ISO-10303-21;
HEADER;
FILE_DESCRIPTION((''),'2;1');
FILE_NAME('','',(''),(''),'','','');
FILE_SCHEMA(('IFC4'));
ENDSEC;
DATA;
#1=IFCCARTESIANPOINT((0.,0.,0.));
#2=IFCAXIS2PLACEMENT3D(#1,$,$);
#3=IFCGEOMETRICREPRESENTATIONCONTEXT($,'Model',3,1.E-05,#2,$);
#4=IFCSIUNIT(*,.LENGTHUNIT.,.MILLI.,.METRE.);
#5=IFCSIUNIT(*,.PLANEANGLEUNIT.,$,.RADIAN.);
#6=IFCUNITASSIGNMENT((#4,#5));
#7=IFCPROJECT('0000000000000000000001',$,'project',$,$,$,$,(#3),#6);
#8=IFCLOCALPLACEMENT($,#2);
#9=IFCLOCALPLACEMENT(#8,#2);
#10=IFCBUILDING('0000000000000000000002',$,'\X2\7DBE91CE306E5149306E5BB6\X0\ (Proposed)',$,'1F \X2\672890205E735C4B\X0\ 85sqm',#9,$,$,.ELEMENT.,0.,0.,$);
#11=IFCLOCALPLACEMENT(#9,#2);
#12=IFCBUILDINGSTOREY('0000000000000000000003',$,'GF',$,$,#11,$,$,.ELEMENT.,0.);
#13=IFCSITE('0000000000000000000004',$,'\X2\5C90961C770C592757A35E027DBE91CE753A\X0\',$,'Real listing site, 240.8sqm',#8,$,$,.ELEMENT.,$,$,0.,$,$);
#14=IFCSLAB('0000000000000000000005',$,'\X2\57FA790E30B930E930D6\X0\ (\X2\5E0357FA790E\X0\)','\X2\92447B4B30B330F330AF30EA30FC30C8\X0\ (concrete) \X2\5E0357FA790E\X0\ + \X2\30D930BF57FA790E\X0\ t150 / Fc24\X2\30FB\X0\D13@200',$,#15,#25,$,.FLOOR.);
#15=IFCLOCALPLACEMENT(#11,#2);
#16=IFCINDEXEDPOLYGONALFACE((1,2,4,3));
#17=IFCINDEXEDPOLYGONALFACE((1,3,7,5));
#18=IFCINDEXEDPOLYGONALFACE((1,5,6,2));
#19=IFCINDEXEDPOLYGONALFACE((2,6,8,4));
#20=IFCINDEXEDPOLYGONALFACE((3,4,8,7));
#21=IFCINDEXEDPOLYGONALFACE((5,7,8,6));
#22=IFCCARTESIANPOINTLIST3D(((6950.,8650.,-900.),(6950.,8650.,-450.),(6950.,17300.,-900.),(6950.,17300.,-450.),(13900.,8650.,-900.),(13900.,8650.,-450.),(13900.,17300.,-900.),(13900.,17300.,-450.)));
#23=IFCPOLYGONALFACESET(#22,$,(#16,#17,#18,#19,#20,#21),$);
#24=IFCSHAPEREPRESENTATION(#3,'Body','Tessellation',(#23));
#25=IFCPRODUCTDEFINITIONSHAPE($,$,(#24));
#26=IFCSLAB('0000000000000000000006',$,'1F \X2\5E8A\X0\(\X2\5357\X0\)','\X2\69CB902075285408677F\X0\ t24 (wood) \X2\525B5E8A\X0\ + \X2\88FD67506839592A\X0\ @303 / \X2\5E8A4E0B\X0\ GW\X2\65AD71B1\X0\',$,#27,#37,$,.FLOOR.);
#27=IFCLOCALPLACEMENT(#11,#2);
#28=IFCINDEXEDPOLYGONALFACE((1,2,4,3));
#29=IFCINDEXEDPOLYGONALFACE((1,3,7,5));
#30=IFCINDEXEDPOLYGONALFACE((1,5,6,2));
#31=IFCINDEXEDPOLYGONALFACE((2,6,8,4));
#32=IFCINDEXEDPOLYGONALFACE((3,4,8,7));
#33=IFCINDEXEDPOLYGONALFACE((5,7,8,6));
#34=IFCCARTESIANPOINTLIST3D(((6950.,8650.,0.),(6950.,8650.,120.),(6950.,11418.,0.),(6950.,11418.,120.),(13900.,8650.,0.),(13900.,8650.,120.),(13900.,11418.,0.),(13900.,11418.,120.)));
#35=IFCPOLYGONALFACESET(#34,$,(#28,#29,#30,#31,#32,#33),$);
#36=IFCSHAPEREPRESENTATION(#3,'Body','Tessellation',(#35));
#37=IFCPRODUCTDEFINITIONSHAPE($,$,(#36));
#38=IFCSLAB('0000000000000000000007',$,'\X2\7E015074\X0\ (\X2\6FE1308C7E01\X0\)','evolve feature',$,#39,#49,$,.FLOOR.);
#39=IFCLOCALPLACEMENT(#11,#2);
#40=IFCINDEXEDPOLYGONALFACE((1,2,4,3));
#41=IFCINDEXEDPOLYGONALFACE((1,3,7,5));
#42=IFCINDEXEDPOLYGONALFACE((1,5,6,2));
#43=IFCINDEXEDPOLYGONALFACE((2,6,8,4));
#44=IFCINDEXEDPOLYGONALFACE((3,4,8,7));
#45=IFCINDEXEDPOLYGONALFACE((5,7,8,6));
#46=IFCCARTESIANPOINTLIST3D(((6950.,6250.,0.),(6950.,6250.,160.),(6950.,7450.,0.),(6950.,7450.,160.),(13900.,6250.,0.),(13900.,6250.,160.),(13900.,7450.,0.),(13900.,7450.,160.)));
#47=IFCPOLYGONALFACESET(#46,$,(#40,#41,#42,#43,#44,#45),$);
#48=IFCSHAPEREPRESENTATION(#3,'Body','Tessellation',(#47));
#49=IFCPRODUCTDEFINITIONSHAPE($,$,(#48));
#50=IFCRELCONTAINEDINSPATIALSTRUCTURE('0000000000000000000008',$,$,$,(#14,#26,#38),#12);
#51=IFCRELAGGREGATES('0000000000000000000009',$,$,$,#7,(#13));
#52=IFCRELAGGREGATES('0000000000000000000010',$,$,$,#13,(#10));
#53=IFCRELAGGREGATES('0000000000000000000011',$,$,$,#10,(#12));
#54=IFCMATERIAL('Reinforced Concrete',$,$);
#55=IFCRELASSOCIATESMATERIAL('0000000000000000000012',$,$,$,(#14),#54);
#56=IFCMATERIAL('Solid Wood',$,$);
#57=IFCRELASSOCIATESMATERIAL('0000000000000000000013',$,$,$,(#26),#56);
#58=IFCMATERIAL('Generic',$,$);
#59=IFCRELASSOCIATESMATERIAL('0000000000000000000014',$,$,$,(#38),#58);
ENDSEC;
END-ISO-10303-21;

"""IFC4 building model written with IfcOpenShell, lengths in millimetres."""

from ifc_helpers import new_model, si_unit, frame, frame_2d, origin, place, context, project, spatial, rectangle, extrude, material, element, save


model = new_model("IFC4")

# Units and contexts
model_context = context("Model", 3, precision=1e-05, world=origin())
ifc_project = project(units=[si_unit("LENGTHUNIT", "METRE", prefix="MILLI"), si_unit("PLANEANGLEUNIT", "RADIAN")], contexts=[model_context])

# Site, building, storey
site_placement = place(None, origin())
site = spatial("IfcSite", under=ifc_project, at=site_placement, Name="岐阜県大垣市綾野町", ObjectType="Real listing site, 240.8sqm", CompositionType="ELEMENT", RefElevation=0.0)
building_placement = place(site_placement, origin())
building = spatial("IfcBuilding", under=site, at=building_placement, Name="綾野の光の家 (Proposed)", ObjectType="1F 木造平屋 85sqm", CompositionType="ELEMENT", ElevationOfRefHeight=0.0, ElevationOfTerrain=0.0)
storey_placement = place(building_placement, origin())
storey = spatial("IfcBuildingStorey", under=building, at=storey_placement, Name="GF", CompositionType="ELEMENT", Elevation=0.0)

# Slabs
ifc_material_1 = material(Name="Reinforced Concrete")
slab_1_placement = place(storey_placement, frame((3475.0, 4325.0, -450.0)))
element("IfcSlab", 1, at=slab_1_placement, inside=storey, material=ifc_material_1, Name="基礎スラブ (布基礎)", Description="鉄筋コンクリート (concrete) 布基礎 + ベタ基礎 t150 / Fc24・D13@200", PredefinedType="FLOOR", context=model_context, shape_type="SweptSolid", body=[
    extrude(rectangle(XDim=6950.0, YDim=8650.0, at=frame_2d((3475.0, 4325.0))), frame((3475.0, 4325.0, -450.0)), (0.0, 0.0, 1.0), 450.0),
])
ifc_material_2 = material(Name="Solid Wood")
slab_2_placement = place(storey_placement, frame((3475.0, 4325.0, 0.0)))
element("IfcSlab", 2, at=slab_2_placement, inside=storey, material=ifc_material_2, Name="1F 床(南)", Description="構造用合板 t24 (wood) 剛床 + 製材根太 @303 / 床下 GW断熱", PredefinedType="FLOOR", context=model_context, shape_type="SweptSolid", body=[
    extrude(rectangle(XDim=6950.0, YDim=2768.0, at=frame_2d((3475.0, 1384.0))), frame((3475.0, 4325.0, 0.0)), (0.0, 0.0, 1.0), 120.0),
])
ifc_material_3 = material(Name="Generic")
slab_3_placement = place(storey_placement, frame((3475.0, 3125.0, 0.0)))
element("IfcSlab", 3, at=slab_3_placement, inside=storey, material=ifc_material_3, Name="縁側 (濡れ縁)", Description="evolve feature", PredefinedType="FLOOR", context=model_context, shape_type="SweptSolid", body=[
    extrude(rectangle(XDim=6950.0, YDim=1200.0, at=frame_2d((3475.0, 600.0))), frame((3475.0, 3125.0, 0.0)), (0.0, 0.0, 1.0), 160.0),
])

save(model, "model.ifc")
